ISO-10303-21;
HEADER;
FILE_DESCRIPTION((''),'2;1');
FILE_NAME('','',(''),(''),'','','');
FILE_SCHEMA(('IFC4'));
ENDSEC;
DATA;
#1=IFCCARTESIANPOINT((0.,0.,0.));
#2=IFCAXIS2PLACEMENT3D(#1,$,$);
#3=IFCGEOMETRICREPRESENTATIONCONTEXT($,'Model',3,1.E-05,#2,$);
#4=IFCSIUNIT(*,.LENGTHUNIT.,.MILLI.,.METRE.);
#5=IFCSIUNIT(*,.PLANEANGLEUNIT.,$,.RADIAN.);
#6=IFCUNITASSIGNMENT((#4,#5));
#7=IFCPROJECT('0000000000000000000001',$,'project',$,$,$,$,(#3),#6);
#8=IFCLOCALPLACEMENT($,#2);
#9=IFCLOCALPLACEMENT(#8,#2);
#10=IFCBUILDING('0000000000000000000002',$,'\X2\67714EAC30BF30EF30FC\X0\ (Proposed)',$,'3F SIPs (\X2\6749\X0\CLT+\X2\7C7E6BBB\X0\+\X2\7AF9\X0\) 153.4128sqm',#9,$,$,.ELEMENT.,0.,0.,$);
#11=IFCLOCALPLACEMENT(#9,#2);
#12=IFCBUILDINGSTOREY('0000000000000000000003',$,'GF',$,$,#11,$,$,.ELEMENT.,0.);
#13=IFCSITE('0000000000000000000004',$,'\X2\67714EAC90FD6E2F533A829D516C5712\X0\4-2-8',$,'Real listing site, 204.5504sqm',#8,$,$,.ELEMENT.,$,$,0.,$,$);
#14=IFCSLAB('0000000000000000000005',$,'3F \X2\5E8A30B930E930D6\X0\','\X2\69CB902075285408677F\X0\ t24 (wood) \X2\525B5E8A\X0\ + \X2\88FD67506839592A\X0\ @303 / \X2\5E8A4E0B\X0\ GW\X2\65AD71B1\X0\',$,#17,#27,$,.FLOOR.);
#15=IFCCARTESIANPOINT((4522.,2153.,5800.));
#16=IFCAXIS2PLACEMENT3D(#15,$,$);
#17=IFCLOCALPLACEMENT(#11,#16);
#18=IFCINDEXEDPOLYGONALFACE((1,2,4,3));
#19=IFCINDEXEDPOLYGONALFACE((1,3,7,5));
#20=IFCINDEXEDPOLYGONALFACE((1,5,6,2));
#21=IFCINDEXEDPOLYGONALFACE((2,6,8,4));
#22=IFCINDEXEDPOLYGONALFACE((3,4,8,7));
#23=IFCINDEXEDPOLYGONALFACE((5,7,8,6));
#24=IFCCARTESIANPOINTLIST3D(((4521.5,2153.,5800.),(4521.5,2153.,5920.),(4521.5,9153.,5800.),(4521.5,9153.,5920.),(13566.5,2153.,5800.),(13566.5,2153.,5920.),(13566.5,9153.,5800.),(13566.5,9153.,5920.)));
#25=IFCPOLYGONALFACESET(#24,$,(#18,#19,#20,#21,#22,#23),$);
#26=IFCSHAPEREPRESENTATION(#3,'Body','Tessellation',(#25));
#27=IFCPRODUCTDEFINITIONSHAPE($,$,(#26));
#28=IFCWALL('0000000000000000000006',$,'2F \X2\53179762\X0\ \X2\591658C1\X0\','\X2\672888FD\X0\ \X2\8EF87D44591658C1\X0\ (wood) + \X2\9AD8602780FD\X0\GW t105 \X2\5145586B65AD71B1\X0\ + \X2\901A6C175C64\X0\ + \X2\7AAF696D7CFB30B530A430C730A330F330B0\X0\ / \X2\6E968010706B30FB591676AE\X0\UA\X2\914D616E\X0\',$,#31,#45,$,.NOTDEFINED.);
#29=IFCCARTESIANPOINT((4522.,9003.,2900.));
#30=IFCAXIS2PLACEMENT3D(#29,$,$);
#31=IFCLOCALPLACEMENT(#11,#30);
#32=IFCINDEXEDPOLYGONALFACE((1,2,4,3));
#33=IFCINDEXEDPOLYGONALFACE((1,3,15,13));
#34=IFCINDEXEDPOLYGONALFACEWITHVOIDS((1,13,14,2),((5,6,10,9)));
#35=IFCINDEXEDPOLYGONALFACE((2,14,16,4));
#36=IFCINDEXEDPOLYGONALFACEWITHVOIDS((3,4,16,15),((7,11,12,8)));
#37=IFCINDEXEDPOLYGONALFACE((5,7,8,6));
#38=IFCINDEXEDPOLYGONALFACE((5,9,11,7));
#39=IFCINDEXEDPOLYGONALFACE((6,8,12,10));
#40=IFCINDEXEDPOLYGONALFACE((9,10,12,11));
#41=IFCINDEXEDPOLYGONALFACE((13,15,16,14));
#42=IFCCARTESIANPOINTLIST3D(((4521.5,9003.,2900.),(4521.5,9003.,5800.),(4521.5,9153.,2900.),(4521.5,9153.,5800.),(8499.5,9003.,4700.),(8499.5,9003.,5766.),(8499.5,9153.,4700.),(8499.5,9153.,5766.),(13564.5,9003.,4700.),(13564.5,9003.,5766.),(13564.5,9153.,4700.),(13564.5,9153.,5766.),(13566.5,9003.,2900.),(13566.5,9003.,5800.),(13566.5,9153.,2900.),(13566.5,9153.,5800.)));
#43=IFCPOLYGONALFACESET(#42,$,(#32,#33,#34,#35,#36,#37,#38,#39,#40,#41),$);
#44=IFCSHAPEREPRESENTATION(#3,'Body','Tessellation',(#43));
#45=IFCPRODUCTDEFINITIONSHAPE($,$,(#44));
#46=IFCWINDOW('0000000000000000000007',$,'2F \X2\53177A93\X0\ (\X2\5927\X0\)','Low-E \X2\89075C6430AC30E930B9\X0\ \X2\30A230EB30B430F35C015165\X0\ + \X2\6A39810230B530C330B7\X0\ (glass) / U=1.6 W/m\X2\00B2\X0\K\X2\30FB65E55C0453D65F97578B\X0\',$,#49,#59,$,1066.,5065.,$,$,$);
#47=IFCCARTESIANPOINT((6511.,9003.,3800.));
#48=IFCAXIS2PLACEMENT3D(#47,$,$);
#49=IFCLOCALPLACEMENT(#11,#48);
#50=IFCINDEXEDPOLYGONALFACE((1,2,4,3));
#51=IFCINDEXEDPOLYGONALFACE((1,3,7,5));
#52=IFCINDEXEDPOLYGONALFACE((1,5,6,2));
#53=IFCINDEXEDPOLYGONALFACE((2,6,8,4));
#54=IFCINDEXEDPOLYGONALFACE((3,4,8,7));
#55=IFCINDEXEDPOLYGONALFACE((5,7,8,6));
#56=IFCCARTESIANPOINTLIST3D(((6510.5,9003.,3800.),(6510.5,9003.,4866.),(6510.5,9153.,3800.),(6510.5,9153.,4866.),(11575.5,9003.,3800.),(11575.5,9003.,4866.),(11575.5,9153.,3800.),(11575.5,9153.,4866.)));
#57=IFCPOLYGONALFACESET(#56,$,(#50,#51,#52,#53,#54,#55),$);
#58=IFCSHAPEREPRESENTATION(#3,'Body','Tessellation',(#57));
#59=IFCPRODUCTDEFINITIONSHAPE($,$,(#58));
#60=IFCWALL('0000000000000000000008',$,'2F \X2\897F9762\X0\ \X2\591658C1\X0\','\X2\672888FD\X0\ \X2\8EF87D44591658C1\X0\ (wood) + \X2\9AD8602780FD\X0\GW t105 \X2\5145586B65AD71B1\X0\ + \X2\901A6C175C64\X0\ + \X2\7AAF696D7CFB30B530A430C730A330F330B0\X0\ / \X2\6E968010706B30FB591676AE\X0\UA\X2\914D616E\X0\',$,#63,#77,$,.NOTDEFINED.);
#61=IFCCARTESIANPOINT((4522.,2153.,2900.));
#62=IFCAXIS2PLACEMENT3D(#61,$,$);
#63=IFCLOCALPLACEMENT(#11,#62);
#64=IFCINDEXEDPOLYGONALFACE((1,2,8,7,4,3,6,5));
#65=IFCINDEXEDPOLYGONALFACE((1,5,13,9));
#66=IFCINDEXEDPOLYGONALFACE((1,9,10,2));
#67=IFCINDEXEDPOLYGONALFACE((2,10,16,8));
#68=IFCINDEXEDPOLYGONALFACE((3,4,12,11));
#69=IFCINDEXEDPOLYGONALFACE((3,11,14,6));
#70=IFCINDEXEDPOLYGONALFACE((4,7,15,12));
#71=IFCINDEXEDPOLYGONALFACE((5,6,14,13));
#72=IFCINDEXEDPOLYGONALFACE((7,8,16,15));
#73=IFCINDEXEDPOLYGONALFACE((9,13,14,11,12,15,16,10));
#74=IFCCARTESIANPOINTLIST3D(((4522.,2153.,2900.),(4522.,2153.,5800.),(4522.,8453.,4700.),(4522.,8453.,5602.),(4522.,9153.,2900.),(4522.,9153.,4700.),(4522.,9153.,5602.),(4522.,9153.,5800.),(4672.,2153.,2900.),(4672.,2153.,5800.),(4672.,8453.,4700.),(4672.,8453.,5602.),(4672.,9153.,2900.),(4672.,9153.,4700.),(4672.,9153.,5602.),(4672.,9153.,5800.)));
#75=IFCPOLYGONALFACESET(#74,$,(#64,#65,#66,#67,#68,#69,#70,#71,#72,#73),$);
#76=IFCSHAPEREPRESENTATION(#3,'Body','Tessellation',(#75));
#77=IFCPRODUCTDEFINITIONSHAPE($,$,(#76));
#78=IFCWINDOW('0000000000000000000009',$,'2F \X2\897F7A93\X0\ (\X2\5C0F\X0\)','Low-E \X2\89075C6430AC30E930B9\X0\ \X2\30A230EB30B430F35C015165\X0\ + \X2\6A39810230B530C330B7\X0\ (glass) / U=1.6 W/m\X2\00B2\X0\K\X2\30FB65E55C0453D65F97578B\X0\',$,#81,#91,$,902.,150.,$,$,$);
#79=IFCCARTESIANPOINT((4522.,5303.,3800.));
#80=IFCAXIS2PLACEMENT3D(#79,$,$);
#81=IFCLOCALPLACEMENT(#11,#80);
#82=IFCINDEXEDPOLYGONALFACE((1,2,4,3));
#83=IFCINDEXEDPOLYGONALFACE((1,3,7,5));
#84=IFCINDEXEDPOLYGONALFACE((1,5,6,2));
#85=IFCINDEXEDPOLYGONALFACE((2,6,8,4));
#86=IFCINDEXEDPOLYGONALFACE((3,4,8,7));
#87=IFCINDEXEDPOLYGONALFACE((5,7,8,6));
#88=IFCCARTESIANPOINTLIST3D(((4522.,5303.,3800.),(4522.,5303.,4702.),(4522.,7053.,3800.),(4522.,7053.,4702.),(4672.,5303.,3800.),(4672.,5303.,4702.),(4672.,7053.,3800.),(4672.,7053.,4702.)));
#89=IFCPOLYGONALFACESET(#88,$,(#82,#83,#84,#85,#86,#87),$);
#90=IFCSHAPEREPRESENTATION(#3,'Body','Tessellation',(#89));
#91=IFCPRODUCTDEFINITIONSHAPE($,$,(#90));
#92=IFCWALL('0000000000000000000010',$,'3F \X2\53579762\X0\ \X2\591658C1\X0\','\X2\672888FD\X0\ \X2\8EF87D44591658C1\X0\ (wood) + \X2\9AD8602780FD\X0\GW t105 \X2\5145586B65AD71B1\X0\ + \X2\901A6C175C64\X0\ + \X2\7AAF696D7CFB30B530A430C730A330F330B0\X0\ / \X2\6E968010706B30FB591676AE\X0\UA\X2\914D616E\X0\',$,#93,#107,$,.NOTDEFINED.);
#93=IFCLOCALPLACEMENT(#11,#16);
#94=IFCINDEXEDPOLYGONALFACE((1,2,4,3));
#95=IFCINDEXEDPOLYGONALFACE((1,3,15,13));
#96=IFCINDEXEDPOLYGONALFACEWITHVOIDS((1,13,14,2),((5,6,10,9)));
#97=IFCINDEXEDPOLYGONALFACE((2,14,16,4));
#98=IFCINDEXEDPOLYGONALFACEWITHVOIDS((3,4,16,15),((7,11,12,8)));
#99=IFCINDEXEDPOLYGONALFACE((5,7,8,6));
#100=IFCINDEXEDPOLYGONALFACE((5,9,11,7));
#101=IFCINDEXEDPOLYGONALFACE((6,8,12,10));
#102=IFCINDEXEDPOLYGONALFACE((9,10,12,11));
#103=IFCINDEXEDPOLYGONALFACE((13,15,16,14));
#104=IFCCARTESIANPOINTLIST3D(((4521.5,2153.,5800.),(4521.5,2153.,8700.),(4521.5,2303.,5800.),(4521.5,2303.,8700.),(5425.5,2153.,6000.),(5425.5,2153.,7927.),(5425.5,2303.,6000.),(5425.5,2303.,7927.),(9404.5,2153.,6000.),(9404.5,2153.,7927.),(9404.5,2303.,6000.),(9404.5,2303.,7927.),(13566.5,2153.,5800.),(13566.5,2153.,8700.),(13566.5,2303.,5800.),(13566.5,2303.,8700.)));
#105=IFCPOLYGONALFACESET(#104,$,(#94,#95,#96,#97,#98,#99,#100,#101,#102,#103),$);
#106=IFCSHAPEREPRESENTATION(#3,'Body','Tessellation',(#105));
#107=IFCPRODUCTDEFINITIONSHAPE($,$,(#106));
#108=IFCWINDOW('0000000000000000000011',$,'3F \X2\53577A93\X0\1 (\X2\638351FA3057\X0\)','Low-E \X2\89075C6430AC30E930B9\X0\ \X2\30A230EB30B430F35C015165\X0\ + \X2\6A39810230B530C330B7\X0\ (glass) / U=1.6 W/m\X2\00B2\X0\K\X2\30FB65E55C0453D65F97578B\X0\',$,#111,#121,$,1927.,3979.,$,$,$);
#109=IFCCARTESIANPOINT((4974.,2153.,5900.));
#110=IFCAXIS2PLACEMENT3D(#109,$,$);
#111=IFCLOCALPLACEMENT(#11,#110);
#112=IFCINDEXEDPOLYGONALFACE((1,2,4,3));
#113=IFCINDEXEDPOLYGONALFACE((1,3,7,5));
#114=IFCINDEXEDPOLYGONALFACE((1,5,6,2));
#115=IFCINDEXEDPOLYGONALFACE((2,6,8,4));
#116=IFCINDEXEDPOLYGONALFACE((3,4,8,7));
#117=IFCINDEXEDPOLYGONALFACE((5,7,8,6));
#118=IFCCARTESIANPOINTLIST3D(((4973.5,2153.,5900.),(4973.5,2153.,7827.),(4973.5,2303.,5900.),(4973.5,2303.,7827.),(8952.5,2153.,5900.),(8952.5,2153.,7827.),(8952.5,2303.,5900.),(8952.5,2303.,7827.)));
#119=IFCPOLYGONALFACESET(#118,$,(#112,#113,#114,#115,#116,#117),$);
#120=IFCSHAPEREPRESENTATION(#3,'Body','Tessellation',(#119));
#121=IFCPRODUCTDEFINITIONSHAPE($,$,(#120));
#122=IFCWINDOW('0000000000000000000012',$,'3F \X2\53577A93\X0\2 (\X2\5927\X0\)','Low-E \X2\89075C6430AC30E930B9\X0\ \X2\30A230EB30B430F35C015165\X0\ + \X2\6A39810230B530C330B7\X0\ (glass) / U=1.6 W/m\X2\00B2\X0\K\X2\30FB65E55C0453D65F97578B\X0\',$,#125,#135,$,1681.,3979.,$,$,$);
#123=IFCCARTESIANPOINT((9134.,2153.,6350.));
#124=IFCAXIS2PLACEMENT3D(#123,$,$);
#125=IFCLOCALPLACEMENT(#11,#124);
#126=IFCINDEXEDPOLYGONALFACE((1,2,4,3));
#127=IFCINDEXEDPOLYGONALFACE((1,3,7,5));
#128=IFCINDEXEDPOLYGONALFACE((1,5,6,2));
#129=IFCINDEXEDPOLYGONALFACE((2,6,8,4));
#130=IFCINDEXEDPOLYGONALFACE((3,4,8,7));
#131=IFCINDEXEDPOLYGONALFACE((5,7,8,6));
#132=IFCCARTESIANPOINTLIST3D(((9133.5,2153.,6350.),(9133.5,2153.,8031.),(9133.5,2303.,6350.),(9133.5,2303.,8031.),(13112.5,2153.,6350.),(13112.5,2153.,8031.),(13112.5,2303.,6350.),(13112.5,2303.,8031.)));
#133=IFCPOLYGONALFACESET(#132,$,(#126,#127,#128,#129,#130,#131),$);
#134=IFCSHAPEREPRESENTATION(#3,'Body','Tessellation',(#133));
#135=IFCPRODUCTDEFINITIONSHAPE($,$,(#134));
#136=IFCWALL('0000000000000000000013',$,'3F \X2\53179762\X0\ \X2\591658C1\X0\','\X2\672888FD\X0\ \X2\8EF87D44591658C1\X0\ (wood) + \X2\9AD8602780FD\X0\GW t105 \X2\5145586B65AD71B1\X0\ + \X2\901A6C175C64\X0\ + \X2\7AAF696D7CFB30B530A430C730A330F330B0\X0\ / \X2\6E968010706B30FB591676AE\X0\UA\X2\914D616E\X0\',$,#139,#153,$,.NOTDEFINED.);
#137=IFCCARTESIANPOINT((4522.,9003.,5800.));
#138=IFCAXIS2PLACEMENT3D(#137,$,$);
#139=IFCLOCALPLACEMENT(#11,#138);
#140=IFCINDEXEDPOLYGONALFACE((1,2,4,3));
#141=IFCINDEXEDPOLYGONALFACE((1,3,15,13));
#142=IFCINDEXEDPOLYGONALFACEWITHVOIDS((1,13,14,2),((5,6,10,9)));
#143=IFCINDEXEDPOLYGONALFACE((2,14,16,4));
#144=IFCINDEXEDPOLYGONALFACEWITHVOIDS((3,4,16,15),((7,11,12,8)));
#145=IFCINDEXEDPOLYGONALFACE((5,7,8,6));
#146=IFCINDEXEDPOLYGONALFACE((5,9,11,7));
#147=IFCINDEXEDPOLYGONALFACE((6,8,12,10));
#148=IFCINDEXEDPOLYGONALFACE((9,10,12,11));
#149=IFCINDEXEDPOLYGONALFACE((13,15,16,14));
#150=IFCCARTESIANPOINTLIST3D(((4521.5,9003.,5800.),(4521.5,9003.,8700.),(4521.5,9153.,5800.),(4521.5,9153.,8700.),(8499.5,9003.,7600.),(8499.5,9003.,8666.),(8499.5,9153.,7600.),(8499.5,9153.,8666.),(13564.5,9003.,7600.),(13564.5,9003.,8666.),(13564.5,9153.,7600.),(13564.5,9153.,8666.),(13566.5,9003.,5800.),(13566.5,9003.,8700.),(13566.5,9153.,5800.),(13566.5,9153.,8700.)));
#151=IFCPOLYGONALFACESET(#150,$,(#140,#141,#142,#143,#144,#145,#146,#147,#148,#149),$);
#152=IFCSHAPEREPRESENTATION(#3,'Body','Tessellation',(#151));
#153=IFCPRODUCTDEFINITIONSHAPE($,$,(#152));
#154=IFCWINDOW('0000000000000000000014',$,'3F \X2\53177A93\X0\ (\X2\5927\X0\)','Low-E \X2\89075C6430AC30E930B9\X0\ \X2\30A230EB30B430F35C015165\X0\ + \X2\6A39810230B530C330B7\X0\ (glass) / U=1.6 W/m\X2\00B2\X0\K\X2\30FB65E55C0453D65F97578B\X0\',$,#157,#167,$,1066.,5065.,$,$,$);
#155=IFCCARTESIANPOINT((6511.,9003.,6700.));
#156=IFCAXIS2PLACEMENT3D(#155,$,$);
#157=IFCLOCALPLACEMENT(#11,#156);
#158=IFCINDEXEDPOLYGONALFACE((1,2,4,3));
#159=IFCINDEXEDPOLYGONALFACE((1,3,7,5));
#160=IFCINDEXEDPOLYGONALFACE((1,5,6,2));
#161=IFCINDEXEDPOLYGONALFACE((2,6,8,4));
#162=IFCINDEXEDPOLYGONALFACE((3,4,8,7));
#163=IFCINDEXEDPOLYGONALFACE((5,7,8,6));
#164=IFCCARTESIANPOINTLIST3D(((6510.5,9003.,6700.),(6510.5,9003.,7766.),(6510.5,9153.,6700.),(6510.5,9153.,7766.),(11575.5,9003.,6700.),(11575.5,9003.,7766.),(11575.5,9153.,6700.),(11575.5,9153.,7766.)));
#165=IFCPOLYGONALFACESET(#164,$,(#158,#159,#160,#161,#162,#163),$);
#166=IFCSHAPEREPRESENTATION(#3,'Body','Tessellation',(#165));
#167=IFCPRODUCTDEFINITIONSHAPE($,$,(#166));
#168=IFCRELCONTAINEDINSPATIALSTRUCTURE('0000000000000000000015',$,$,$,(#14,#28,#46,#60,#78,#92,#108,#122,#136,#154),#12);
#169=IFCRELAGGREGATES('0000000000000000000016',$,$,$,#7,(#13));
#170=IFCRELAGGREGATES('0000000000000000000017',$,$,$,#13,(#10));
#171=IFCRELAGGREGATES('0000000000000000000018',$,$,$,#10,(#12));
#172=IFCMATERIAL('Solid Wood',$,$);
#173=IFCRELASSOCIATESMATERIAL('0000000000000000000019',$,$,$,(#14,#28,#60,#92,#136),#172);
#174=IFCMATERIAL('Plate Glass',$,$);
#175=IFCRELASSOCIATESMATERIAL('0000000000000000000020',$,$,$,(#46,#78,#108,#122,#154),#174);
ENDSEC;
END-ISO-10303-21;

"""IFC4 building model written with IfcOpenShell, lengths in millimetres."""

from ifc_helpers import new_model, si_unit, frame, frame_2d, origin, place, context, project, spatial, rectangle, extrude, material, element, fill, save


model = new_model("IFC4")

# Units and contexts
model_context = context("Model", 3, precision=1e-05, world=origin())
ifc_project = project(units=[si_unit("LENGTHUNIT", "METRE", prefix="MILLI"), si_unit("PLANEANGLEUNIT", "RADIAN")], contexts=[model_context])

# Site, building, storey
site_placement = place(None, origin())
site = spatial("IfcSite", under=ifc_project, at=site_placement, Name="東京都港区芝公園4-2-8", ObjectType="Real listing site, 204.5504sqm", CompositionType="ELEMENT", RefElevation=0.0)
building_placement = place(site_placement, origin())
building = spatial("IfcBuilding", under=site, at=building_placement, Name="東京タワー (Proposed)", ObjectType="3F SIPs (杉CLT+籾殻+竹) 153.4128sqm", CompositionType="ELEMENT", ElevationOfRefHeight=0.0, ElevationOfTerrain=0.0)
storey_placement = place(building_placement, origin())
storey = spatial("IfcBuildingStorey", under=building, at=storey_placement, Name="GF", CompositionType="ELEMENT", Elevation=0.0)

# Slab
ifc_material_1 = material(Name="Solid Wood")
slab_placement = place(storey_placement, frame((4522.0, 2153.0, 5800.0)))
element("IfcSlab", 1, at=slab_placement, inside=storey, material=ifc_material_1, Name="3F 床スラブ", Description="構造用合板 t24 (wood) 剛床 + 製材根太 @303 / 床下 GW断熱", PredefinedType="FLOOR", context=model_context, shape_type="SweptSolid", body=[
    extrude(rectangle(XDim=9045.0, YDim=7000.0, at=frame_2d((4522.0, 3500.0))), frame((4522.0, 2153.0, 5800.0)), (0.0, 0.0, 1.0), 120.0),
])

# Walls, openings, windows
wall_1_placement = place(storey_placement, frame((4522.0, 9003.0, 2900.0)))
wall_1 = element("IfcWall", 2, at=wall_1_placement, inside=storey, material=ifc_material_1, Name="2F 北面 外壁", Description="木製 軸組外壁 (wood) + 高性能GW t105 充填断熱 + 通気層 + 窯業系サイディング / 準耐火・外皮UA配慮", PredefinedType="NOTDEFINED", context=model_context, shape_type="SweptSolid", body=[
    extrude(rectangle(XDim=9045.0, YDim=150.0, at=frame_2d((4522.0, 75.0))), frame((4522.0, 9003.0, 2900.0)), (0.0, 0.0, 1.0), 2900.0),
])
opening_1_placement = place(storey_placement, frame((6511.0, 9003.0, 3800.0)))
opening_1 = element("IfcOpeningElement", 3, at=opening_1_placement, cuts=wall_1, PredefinedType="NOTDEFINED", context=model_context, shape_type="SweptSolid", body=[
    extrude(rectangle(XDim=5065.0, YDim=150.0, at=frame_2d((2532.0, 75.0))), frame((6511.0, 9003.0, 3800.0)), (0.0, 0.0, 1.0), 1066.0),
])
ifc_material_2 = material(Name="Plate Glass")
window_1_placement = place(storey_placement, frame((6511.0, 9003.0, 3800.0)))
window_1 = element("IfcWindow", 4, at=window_1_placement, inside=storey, material=ifc_material_2, Name="2F 北窓 (大)", Description="Low-E 複層ガラス アルゴン封入 + 樹脂サッシ (glass) / U=1.6 W/m²K・日射取得型", OverallHeight=1066.0, OverallWidth=5065.0, context=model_context, shape_type="SweptSolid", body=[
    extrude(rectangle(XDim=5065.0, YDim=150.0, at=frame_2d((2532.0, 75.0))), frame((6511.0, 9003.0, 3800.0)), (0.0, 0.0, 1.0), 1066.0),
])
fill(opening_1, window_1)
wall_2_placement = place(storey_placement, frame((4522.0, 2153.0, 2900.0)))
wall_2 = element("IfcWall", 5, at=wall_2_placement, inside=storey, material=ifc_material_1, Name="2F 西面 外壁", Description="木製 軸組外壁 (wood) + 高性能GW t105 充填断熱 + 通気層 + 窯業系サイディング / 準耐火・外皮UA配慮", PredefinedType="NOTDEFINED", context=model_context, shape_type="SweptSolid", body=[
    extrude(rectangle(XDim=150.0, YDim=7000.0, at=frame_2d((75.0, 3500.0))), frame((4522.0, 2153.0, 2900.0)), (0.0, 0.0, 1.0), 2900.0),
])
opening_2_placement = place(storey_placement, frame((4522.0, 5303.0, 3800.0)))
opening_2 = element("IfcOpeningElement", 6, at=opening_2_placement, cuts=wall_2, PredefinedType="NOTDEFINED", context=model_context, shape_type="SweptSolid", body=[
    extrude(rectangle(XDim=150.0, YDim=1750.0, at=frame_2d((75.0, 875.0))), frame((4522.0, 5303.0, 3800.0)), (0.0, 0.0, 1.0), 902.0),
])
window_2_placement = place(storey_placement, frame((4522.0, 5303.0, 3800.0)))
window_2 = element("IfcWindow", 7, at=window_2_placement, inside=storey, material=ifc_material_2, Name="2F 西窓 (小)", Description="Low-E 複層ガラス アルゴン封入 + 樹脂サッシ (glass) / U=1.6 W/m²K・日射取得型", OverallHeight=902.0, OverallWidth=150.0, context=model_context, shape_type="SweptSolid", body=[
    extrude(rectangle(XDim=150.0, YDim=1750.0, at=frame_2d((75.0, 875.0))), frame((4522.0, 5303.0, 3800.0)), (0.0, 0.0, 1.0), 902.0),
])
fill(opening_2, window_2)

# Wall, openings, windows
wall_3_placement = place(storey_placement, frame((4522.0, 2153.0, 5800.0)))
wall_3 = element("IfcWall", 8, at=wall_3_placement, inside=storey, material=ifc_material_1, Name="3F 南面 外壁", Description="木製 軸組外壁 (wood) + 高性能GW t105 充填断熱 + 通気層 + 窯業系サイディング / 準耐火・外皮UA配慮", PredefinedType="NOTDEFINED", context=model_context, shape_type="SweptSolid", body=[
    extrude(rectangle(XDim=9045.0, YDim=150.0, at=frame_2d((4522.0, 75.0))), frame((4522.0, 2153.0, 5800.0)), (0.0, 0.0, 1.0), 2900.0),
])
opening_3_placement = place(storey_placement, frame((4974.0, 2153.0, 5900.0)))
opening_3 = element("IfcOpeningElement", 9, at=opening_3_placement, cuts=wall_3, PredefinedType="NOTDEFINED", context=model_context, shape_type="SweptSolid", body=[
    extrude(rectangle(XDim=3979.0, YDim=150.0, at=frame_2d((1989.0, 75.0))), frame((4974.0, 2153.0, 5900.0)), (0.0, 0.0, 1.0), 1927.0),
])
opening_4_placement = place(storey_placement, frame((9134.0, 2153.0, 6350.0)))
opening_4 = element("IfcOpeningElement", 10, at=opening_4_placement, cuts=wall_3, PredefinedType="NOTDEFINED", context=model_context, shape_type="SweptSolid", body=[
    extrude(rectangle(XDim=3979.0, YDim=150.0, at=frame_2d((1989.0, 75.0))), frame((9134.0, 2153.0, 6350.0)), (0.0, 0.0, 1.0), 1681.0),
])
window_3_placement = place(storey_placement, frame((4974.0, 2153.0, 5900.0)))
window_3 = element("IfcWindow", 11, at=window_3_placement, inside=storey, material=ifc_material_2, Name="3F 南窓1 (掃出し)", Description="Low-E 複層ガラス アルゴン封入 + 樹脂サッシ (glass) / U=1.6 W/m²K・日射取得型", OverallHeight=1927.0, OverallWidth=3979.0, context=model_context, shape_type="SweptSolid", body=[
    extrude(rectangle(XDim=3979.0, YDim=150.0, at=frame_2d((1989.0, 75.0))), frame((4974.0, 2153.0, 5900.0)), (0.0, 0.0, 1.0), 1927.0),
])
fill(opening_3, window_3)
window_4_placement = place(storey_placement, frame((9134.0, 2153.0, 6350.0)))
window_4 = element("IfcWindow", 12, at=window_4_placement, inside=storey, material=ifc_material_2, Name="3F 南窓2 (大)", Description="Low-E 複層ガラス アルゴン封入 + 樹脂サッシ (glass) / U=1.6 W/m²K・日射取得型", OverallHeight=1681.0, OverallWidth=3979.0, context=model_context, shape_type="SweptSolid", body=[
    extrude(rectangle(XDim=3979.0, YDim=150.0, at=frame_2d((1989.0, 75.0))), frame((9134.0, 2153.0, 6350.0)), (0.0, 0.0, 1.0), 1681.0),
])
fill(opening_4, window_4)

# Wall, opening, window
wall_4_placement = place(storey_placement, frame((4522.0, 9003.0, 5800.0)))
wall_4 = element("IfcWall", 13, at=wall_4_placement, inside=storey, material=ifc_material_1, Name="3F 北面 外壁", Description="木製 軸組外壁 (wood) + 高性能GW t105 充填断熱 + 通気層 + 窯業系サイディング / 準耐火・外皮UA配慮", PredefinedType="NOTDEFINED", context=model_context, shape_type="SweptSolid", body=[
    extrude(rectangle(XDim=9045.0, YDim=150.0, at=frame_2d((4522.0, 75.0))), frame((4522.0, 9003.0, 5800.0)), (0.0, 0.0, 1.0), 2900.0),
])
opening_5_placement = place(storey_placement, frame((6511.0, 9003.0, 6700.0)))
opening_5 = element("IfcOpeningElement", 14, at=opening_5_placement, cuts=wall_4, PredefinedType="NOTDEFINED", context=model_context, shape_type="SweptSolid", body=[
    extrude(rectangle(XDim=5065.0, YDim=150.0, at=frame_2d((2532.0, 75.0))), frame((6511.0, 9003.0, 6700.0)), (0.0, 0.0, 1.0), 1066.0),
])
window_5_placement = place(storey_placement, frame((6511.0, 9003.0, 6700.0)))
window_5 = element("IfcWindow", 15, at=window_5_placement, inside=storey, material=ifc_material_2, Name="3F 北窓 (大)", Description="Low-E 複層ガラス アルゴン封入 + 樹脂サッシ (glass) / U=1.6 W/m²K・日射取得型", OverallHeight=1066.0, OverallWidth=5065.0, context=model_context, shape_type="SweptSolid", body=[
    extrude(rectangle(XDim=5065.0, YDim=150.0, at=frame_2d((2532.0, 75.0))), frame((6511.0, 9003.0, 6700.0)), (0.0, 0.0, 1.0), 1066.0),
])
fill(opening_5, window_5)

save(model, "model.ifc")
